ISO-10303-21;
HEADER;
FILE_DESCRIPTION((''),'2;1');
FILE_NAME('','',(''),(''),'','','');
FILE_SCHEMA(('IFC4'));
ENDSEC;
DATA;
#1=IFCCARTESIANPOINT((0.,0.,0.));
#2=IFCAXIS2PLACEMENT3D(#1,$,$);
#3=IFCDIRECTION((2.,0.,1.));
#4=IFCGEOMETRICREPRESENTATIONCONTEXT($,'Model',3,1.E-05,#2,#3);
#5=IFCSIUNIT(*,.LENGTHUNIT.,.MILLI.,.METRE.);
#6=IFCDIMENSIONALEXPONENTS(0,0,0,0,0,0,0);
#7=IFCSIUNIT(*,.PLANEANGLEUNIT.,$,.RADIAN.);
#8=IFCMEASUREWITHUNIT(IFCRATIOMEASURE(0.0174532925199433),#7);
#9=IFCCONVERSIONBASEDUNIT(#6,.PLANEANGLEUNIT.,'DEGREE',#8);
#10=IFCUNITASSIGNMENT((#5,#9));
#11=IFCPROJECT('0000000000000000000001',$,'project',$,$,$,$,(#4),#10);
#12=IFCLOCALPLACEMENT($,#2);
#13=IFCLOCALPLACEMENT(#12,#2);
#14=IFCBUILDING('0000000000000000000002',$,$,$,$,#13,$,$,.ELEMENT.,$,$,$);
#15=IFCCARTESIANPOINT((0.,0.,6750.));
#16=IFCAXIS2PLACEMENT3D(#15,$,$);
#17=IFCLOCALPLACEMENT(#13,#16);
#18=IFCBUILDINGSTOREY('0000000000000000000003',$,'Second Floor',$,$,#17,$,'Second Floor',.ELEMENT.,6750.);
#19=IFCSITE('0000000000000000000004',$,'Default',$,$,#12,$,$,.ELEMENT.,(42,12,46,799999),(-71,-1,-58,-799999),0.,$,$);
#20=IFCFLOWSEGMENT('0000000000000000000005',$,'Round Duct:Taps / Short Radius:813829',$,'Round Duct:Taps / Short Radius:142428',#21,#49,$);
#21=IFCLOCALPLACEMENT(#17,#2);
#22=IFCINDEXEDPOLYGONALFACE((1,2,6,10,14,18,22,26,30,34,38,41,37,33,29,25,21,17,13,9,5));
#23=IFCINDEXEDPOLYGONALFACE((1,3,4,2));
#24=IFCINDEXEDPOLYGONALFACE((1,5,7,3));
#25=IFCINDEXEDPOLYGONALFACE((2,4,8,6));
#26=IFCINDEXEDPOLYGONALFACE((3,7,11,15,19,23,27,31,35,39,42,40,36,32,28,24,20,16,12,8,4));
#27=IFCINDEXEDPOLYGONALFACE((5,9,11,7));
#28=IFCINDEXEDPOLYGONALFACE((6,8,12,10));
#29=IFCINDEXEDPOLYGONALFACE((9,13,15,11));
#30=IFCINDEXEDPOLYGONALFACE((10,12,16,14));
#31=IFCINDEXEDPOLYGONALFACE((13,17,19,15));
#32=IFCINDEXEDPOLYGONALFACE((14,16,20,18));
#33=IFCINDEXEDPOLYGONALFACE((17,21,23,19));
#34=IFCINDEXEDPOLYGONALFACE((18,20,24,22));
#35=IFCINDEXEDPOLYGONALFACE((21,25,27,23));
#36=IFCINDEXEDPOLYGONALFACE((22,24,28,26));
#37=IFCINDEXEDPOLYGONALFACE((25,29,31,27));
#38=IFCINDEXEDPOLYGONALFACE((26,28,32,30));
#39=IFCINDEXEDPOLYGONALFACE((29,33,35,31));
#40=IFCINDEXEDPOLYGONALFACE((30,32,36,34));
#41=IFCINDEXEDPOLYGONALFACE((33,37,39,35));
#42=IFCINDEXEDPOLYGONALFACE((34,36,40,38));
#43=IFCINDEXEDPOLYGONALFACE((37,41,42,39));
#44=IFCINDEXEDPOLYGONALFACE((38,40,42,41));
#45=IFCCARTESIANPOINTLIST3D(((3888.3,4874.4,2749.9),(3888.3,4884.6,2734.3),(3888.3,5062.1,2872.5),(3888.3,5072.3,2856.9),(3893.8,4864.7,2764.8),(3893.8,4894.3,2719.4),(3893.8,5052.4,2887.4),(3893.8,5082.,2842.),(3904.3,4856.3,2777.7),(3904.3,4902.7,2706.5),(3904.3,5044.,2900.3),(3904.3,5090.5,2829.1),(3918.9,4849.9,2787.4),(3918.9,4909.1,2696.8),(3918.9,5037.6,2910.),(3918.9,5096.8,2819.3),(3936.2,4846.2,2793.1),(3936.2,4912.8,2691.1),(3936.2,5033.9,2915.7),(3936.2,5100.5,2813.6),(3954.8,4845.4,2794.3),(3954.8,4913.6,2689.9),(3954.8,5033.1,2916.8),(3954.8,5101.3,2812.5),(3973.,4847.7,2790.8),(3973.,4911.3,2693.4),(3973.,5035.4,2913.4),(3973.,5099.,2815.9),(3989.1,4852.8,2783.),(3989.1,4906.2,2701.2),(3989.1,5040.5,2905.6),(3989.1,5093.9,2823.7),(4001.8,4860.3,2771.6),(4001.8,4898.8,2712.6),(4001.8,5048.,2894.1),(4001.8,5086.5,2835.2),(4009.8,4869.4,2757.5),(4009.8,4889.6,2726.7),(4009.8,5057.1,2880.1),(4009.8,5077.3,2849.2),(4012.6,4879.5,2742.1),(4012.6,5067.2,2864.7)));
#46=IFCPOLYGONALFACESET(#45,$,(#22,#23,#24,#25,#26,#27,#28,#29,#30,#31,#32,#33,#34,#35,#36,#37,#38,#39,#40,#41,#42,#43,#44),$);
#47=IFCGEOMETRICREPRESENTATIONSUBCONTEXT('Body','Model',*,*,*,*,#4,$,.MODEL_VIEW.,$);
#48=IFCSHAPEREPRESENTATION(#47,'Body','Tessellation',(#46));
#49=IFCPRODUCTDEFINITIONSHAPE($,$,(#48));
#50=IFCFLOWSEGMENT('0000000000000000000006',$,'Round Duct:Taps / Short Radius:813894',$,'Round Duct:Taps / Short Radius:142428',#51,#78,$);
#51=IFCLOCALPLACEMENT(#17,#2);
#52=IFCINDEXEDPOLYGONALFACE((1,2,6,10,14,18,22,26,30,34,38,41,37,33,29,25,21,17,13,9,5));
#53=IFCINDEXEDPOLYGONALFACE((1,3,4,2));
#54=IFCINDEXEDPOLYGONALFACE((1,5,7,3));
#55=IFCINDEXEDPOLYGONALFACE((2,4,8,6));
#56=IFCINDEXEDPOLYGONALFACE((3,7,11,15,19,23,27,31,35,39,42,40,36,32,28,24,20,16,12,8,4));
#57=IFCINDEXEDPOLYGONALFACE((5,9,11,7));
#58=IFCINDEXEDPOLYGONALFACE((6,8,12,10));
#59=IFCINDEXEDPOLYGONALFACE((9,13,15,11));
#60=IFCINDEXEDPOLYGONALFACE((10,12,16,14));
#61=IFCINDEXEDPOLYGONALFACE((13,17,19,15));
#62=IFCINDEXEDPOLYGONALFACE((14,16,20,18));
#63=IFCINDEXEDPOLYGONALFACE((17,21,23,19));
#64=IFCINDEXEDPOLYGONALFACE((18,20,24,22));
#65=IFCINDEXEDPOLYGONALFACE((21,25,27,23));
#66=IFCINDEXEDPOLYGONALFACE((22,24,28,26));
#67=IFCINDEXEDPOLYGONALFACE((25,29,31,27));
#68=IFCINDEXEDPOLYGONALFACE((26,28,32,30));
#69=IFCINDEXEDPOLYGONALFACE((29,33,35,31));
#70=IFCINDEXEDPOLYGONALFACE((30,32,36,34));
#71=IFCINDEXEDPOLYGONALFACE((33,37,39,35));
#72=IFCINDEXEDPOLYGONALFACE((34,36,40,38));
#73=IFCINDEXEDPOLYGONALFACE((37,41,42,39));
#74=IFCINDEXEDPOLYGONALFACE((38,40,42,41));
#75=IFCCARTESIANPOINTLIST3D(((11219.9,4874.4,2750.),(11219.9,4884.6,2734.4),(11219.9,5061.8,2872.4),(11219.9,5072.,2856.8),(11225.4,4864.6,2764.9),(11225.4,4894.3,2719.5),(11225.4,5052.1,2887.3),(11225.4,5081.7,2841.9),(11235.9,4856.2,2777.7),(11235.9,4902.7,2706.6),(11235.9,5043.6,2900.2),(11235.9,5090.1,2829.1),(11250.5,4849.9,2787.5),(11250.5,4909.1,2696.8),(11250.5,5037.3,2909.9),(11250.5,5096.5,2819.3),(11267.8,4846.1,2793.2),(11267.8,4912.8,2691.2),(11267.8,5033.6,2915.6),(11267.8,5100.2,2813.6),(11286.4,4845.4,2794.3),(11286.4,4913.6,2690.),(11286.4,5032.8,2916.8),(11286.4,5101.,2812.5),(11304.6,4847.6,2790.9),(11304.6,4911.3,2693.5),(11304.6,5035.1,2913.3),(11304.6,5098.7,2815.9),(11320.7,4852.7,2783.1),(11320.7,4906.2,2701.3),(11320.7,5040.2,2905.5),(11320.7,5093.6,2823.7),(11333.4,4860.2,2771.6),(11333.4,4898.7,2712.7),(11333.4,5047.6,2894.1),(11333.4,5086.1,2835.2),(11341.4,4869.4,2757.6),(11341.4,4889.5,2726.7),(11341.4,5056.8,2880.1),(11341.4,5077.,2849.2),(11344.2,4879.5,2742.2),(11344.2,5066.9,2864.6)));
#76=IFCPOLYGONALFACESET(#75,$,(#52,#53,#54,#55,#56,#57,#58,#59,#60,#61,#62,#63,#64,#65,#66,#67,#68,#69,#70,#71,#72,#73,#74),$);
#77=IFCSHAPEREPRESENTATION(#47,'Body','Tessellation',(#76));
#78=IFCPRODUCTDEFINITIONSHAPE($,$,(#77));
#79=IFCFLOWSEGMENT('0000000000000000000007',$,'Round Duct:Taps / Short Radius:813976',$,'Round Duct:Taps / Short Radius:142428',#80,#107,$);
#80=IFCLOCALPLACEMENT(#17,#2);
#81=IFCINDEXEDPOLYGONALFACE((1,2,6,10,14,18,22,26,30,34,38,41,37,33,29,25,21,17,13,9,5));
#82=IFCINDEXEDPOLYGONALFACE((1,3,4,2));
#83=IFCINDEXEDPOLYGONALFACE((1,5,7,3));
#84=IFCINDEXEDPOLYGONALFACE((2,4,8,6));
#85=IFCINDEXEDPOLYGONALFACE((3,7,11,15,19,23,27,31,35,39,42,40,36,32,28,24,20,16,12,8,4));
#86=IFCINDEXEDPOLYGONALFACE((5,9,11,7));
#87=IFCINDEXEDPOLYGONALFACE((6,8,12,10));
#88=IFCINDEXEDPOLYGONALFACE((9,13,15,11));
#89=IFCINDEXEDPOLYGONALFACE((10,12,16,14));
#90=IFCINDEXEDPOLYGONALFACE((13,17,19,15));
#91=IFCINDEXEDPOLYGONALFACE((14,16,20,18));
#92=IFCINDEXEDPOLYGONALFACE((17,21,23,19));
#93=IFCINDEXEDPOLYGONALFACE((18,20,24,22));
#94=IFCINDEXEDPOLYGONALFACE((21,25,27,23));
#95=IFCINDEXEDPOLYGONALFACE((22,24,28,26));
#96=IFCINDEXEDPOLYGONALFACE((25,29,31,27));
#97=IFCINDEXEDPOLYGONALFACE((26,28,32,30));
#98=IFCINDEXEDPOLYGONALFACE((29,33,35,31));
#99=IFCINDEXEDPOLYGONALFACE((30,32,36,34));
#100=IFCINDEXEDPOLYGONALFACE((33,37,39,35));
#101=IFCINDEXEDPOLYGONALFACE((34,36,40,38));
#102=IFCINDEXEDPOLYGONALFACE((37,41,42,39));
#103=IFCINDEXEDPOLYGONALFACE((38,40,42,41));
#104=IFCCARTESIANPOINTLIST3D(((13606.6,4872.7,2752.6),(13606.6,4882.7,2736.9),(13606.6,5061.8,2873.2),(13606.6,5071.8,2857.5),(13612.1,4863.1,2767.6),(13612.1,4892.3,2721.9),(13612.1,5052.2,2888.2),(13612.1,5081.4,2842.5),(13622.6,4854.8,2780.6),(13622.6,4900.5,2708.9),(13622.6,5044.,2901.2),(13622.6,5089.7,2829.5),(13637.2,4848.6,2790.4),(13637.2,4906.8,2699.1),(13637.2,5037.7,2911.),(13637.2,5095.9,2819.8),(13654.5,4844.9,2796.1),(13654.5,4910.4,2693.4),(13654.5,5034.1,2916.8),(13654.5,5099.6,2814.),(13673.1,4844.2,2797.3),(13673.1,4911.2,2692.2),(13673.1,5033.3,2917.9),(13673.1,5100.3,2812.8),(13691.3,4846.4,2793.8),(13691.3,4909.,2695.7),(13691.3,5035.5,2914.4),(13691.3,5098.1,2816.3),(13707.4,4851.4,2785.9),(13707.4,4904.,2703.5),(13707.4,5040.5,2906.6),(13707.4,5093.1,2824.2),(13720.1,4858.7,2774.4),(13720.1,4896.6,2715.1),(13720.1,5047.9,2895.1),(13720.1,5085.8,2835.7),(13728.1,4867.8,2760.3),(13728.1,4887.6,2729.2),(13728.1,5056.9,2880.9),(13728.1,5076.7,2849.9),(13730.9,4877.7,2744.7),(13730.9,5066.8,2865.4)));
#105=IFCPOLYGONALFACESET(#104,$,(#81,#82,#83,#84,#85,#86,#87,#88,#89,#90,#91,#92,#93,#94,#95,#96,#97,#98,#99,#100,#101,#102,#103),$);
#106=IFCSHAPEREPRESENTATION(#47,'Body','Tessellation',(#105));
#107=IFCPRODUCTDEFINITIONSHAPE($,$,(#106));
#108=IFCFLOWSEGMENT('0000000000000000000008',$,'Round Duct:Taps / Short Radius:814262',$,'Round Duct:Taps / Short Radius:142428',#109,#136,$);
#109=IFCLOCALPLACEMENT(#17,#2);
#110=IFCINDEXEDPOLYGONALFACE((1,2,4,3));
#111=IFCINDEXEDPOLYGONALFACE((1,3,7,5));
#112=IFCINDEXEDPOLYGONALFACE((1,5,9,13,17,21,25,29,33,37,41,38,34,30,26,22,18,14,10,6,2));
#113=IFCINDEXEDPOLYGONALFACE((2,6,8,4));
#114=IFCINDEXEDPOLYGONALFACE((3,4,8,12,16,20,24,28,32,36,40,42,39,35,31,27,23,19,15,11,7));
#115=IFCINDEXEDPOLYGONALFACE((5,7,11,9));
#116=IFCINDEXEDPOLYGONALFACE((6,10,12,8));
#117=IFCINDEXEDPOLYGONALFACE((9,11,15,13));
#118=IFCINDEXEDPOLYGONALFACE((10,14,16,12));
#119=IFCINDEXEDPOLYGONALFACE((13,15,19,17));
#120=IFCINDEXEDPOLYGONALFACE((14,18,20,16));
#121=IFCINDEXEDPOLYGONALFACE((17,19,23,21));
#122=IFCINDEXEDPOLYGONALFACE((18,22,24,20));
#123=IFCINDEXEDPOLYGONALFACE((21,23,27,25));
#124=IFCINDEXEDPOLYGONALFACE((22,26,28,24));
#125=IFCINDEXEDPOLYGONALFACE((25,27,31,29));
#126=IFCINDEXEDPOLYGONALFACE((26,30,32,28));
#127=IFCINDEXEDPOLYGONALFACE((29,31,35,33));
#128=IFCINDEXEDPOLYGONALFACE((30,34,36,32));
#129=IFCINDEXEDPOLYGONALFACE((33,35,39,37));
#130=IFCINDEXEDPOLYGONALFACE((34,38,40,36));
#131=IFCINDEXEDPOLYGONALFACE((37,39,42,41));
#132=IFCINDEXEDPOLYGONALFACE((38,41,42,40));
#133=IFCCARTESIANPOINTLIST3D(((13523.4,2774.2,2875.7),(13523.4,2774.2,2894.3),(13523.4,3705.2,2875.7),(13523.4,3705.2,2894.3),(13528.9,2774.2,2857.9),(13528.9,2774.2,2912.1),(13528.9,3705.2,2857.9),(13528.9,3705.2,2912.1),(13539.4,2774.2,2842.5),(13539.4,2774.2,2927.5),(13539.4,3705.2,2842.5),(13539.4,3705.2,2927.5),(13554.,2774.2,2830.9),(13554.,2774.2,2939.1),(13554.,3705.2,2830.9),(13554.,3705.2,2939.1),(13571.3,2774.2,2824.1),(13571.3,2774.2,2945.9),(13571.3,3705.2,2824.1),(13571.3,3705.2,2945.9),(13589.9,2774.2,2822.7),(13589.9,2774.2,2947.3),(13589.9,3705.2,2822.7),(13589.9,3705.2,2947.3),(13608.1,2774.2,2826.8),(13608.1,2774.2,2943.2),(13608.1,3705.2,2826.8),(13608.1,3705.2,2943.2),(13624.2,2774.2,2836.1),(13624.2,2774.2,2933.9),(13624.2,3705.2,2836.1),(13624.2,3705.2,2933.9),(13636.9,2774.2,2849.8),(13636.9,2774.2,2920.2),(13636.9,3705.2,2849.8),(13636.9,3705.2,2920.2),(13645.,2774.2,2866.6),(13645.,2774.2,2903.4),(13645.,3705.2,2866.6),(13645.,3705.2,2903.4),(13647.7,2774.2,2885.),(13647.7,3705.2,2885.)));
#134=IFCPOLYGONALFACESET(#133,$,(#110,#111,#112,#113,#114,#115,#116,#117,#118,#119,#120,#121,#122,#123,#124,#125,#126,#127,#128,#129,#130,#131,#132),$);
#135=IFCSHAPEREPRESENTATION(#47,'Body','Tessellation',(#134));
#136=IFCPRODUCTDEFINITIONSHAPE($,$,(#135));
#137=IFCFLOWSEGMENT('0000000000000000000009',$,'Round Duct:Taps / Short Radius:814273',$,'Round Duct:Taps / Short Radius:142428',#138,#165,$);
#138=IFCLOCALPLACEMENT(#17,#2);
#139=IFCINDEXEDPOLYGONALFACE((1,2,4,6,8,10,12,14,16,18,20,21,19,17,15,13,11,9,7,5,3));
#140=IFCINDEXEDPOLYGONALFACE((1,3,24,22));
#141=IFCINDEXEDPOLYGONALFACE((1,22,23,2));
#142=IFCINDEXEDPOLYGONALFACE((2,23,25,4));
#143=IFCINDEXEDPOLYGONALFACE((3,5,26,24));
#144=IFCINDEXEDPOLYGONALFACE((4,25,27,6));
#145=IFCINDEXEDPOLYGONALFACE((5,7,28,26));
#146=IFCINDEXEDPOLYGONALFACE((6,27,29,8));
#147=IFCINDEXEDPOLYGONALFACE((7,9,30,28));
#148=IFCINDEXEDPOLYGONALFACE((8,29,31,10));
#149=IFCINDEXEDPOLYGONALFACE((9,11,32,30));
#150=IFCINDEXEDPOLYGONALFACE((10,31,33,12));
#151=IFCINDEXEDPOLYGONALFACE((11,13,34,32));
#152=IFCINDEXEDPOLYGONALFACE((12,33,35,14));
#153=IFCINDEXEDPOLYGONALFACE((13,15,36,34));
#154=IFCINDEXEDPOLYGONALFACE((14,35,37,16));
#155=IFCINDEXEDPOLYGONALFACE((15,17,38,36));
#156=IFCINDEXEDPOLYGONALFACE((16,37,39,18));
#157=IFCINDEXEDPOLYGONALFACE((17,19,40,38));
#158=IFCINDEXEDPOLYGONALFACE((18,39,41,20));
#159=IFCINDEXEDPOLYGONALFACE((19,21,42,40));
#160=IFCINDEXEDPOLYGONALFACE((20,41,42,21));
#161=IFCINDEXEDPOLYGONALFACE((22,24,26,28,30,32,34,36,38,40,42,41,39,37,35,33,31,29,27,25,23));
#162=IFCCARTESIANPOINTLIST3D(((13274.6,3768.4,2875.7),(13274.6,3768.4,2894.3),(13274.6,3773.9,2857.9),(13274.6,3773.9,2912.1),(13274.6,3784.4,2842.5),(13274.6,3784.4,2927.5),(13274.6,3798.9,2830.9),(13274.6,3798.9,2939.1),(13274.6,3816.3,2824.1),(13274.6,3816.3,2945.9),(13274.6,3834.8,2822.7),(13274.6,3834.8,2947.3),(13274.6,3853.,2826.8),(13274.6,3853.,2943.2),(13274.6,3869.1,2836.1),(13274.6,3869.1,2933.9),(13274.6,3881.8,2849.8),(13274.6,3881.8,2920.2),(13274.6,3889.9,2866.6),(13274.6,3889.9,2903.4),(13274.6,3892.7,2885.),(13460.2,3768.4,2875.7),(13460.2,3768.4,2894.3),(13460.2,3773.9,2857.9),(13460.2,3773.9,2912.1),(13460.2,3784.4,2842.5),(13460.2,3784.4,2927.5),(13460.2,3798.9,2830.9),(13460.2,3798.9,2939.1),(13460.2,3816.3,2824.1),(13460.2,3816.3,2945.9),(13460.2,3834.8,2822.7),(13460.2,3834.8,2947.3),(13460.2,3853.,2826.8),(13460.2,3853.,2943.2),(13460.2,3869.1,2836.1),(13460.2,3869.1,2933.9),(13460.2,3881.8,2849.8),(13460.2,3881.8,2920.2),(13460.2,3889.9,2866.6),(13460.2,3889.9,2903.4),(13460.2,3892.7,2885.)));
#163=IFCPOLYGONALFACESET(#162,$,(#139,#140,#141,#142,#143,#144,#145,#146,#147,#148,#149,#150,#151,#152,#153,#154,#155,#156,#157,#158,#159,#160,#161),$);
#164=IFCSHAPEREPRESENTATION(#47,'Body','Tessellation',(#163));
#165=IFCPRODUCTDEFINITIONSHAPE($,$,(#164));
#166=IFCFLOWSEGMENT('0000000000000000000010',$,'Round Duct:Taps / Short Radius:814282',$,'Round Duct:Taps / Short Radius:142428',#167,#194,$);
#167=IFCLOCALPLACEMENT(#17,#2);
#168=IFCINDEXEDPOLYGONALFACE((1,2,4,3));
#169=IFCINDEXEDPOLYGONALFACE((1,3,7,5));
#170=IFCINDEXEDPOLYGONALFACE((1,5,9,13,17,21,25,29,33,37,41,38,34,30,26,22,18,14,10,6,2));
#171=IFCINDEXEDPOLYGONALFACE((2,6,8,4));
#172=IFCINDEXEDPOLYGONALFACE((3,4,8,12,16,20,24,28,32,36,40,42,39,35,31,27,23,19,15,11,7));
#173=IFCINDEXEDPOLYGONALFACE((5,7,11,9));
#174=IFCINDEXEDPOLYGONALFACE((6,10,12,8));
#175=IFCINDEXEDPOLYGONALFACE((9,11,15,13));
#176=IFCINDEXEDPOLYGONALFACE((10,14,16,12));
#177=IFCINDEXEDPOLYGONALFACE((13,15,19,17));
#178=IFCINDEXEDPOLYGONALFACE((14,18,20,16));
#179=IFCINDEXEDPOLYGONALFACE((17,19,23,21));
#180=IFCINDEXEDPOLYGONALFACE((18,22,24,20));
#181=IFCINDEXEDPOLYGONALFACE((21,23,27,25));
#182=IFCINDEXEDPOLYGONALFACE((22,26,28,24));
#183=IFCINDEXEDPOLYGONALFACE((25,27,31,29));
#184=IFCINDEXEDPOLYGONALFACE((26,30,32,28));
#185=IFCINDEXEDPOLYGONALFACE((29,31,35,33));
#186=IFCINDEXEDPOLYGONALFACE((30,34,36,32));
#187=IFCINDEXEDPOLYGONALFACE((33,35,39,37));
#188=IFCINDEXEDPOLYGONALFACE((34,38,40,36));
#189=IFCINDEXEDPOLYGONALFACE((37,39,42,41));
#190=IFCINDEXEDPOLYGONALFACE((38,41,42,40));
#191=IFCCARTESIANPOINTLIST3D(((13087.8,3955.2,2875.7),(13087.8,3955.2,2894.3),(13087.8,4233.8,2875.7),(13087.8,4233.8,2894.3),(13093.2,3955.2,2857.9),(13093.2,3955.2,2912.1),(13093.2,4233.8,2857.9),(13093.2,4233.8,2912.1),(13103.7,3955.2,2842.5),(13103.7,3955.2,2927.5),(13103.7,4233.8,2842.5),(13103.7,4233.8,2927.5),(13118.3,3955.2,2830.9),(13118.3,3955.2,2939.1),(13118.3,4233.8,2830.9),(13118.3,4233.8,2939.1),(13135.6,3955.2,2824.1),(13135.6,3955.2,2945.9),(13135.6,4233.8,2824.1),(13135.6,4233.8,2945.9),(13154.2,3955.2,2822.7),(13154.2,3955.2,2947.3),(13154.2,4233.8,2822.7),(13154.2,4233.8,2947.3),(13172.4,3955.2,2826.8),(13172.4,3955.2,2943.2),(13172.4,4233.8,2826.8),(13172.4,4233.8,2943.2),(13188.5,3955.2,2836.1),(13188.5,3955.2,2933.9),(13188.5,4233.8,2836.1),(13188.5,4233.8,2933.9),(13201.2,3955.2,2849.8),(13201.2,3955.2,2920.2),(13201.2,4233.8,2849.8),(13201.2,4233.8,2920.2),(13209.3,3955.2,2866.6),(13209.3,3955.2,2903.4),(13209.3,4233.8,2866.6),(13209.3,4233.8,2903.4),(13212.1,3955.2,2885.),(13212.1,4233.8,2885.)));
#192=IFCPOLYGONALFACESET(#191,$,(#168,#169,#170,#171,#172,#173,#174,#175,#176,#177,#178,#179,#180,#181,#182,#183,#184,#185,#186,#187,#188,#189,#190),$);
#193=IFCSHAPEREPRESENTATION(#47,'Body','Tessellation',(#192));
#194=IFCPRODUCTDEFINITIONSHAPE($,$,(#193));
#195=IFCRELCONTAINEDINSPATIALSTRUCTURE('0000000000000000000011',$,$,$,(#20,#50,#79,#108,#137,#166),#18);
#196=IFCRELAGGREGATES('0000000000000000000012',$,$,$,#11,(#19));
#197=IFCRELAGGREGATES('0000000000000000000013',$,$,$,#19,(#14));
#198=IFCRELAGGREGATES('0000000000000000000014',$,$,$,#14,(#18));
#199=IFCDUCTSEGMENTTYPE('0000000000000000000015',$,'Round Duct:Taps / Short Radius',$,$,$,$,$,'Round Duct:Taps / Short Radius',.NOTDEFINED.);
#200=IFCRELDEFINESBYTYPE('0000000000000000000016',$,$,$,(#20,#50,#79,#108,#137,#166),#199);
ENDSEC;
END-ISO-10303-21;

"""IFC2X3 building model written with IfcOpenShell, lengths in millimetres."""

from ifc_helpers import new_model, entity, si_unit, converted_unit, direction, frame, frame_2d, origin, origin_2d_with_axis, place, context, subcontext, project, spatial, circle, extrude, type_object, element, save


model = new_model("IFC2X3")

# Units and contexts
model_context = context("Model", 3, precision=1e-05, world=origin(), true_north=direction((2.0, 0.0, 1.0)))
body_context = subcontext(model_context, "Body", "Model", "MODEL_VIEW")
ifc_project = project(units=[si_unit("LENGTHUNIT", "METRE", prefix="MILLI"), converted_unit("PLANEANGLEUNIT", "DEGREE", entity("IfcRatioMeasure", 0.0174532925199433), si_unit("PLANEANGLEUNIT", "RADIAN"), dimensions=[0, 0, 0, 0, 0, 0, 0])], contexts=[model_context])

# Site, building, storey
site_placement = place(None, origin())
site = spatial("IfcSite", under=ifc_project, at=site_placement, Name="Default", CompositionType="ELEMENT", RefLatitude=(42, 12, 46, 799999), RefLongitude=(-71, -1, -58, -799999), RefElevation=0.0)
building_placement = place(site_placement, origin())
building = spatial("IfcBuilding", under=site, at=building_placement, CompositionType="ELEMENT")
storey_placement = place(building_placement, frame((0.0, 0.0, 6750.0)))
storey = spatial("IfcBuildingStorey", under=building, at=storey_placement, Name="Second Floor", LongName="Second Floor", CompositionType="ELEMENT", Elevation=6750.0)

# Flow segments
duct_segment_type = type_object("IfcDuctSegmentType", Name="Round Duct:Taps / Short Radius", ElementType="Round Duct:Taps / Short Radius", PredefinedType="NOTDEFINED")
flow_segment_1_placement = place(storey_placement, origin())
element("IfcFlowSegment", 1, at=flow_segment_1_placement, inside=storey, type_object=duct_segment_type, Name="Round Duct:Taps / Short Radius:813829", ObjectType="Round Duct:Taps / Short Radius:142428", context=body_context, shape_type="SweptSolid", body=[
    extrude(circle(Radius=62.5, at=frame_2d((0.0, 0.0), x_axis=(1.0, 0.0))), frame((3950.1, 4879.5, 2742.1), z_axis=(0.0, 0.837298, 0.546747), x_axis=(1.0, 0.0, 0.0)), (0.0, 0.0, 1.0), 224.2),
])
flow_segment_2_placement = place(storey_placement, origin())
element("IfcFlowSegment", 2, at=flow_segment_2_placement, inside=storey, type_object=duct_segment_type, Name="Round Duct:Taps / Short Radius:813894", ObjectType="Round Duct:Taps / Short Radius:142428", context=body_context, shape_type="SweptSolid", body=[
    extrude(circle(Radius=62.5, at=frame_2d((0.0, 0.0), x_axis=(1.0, 0.0))), frame((11281.7, 4879.5, 2742.2), z_axis=(0.0, 0.837109, 0.547036), x_axis=(1.0, 0.0, 0.0)), (0.0, 0.0, 1.0), 223.9),
])
flow_segment_3_placement = place(storey_placement, origin())
element("IfcFlowSegment", 3, at=flow_segment_3_placement, inside=storey, type_object=duct_segment_type, Name="Round Duct:Taps / Short Radius:813976", ObjectType="Round Duct:Taps / Short Radius:142428", context=body_context, shape_type="SweptSolid", body=[
    extrude(circle(Radius=62.5, at=frame_2d((0.0, 0.0), x_axis=(1.0, 0.0))), frame((13668.4, 4877.7, 2744.7), z_axis=(0.0, 0.84309, 0.537772), x_axis=(1.0, 0.0, 0.0)), (0.0, 0.0, 1.0), 224.3),
])
flow_segment_4_placement = place(storey_placement, origin())
element("IfcFlowSegment", 4, at=flow_segment_4_placement, inside=storey, type_object=duct_segment_type, Name="Round Duct:Taps / Short Radius:814262", ObjectType="Round Duct:Taps / Short Radius:142428", context=body_context, shape_type="SweptSolid", body=[
    extrude(circle(Radius=62.5, at=frame_2d((0.0, 0.0), x_axis=(1.0, 0.0))), frame((13585.2, 2774.2, 2885.0), z_axis=(0.0, 1.0, 0.0), x_axis=(1.0, 0.0, 0.0)), (0.0, 0.0, 1.0), 931.0),
])
flow_segment_5_placement = place(storey_placement, origin())
element("IfcFlowSegment", 5, at=flow_segment_5_placement, inside=storey, type_object=duct_segment_type, Name="Round Duct:Taps / Short Radius:814273", ObjectType="Round Duct:Taps / Short Radius:142428", context=body_context, shape_type="SweptSolid", body=[
    extrude(circle(Radius=62.5, at=frame_2d((0.0, 0.0), x_axis=(1.0, 0.0))), frame((13274.6, 3830.2, 2885.0), z_axis=(1.0, 0.0, 0.0), x_axis=(0.0, 1.0, 0.0)), (0.0, 0.0, 1.0), 185.7),
])
flow_segment_6_placement = place(storey_placement, origin())
element("IfcFlowSegment", 6, at=flow_segment_6_placement, inside=storey, type_object=duct_segment_type, Name="Round Duct:Taps / Short Radius:814282", ObjectType="Round Duct:Taps / Short Radius:142428", context=body_context, shape_type="SweptSolid", body=[
    extrude(circle(Radius=62.5, at=origin_2d_with_axis()), frame((13149.6, 3955.2, 2885.0), z_axis=(0.0, 1.0, 0.0), x_axis=(1.0, 0.0, 0.0)), (0.0, 0.0, 1.0), 278.6),
])

save(model, "model.ifc")
